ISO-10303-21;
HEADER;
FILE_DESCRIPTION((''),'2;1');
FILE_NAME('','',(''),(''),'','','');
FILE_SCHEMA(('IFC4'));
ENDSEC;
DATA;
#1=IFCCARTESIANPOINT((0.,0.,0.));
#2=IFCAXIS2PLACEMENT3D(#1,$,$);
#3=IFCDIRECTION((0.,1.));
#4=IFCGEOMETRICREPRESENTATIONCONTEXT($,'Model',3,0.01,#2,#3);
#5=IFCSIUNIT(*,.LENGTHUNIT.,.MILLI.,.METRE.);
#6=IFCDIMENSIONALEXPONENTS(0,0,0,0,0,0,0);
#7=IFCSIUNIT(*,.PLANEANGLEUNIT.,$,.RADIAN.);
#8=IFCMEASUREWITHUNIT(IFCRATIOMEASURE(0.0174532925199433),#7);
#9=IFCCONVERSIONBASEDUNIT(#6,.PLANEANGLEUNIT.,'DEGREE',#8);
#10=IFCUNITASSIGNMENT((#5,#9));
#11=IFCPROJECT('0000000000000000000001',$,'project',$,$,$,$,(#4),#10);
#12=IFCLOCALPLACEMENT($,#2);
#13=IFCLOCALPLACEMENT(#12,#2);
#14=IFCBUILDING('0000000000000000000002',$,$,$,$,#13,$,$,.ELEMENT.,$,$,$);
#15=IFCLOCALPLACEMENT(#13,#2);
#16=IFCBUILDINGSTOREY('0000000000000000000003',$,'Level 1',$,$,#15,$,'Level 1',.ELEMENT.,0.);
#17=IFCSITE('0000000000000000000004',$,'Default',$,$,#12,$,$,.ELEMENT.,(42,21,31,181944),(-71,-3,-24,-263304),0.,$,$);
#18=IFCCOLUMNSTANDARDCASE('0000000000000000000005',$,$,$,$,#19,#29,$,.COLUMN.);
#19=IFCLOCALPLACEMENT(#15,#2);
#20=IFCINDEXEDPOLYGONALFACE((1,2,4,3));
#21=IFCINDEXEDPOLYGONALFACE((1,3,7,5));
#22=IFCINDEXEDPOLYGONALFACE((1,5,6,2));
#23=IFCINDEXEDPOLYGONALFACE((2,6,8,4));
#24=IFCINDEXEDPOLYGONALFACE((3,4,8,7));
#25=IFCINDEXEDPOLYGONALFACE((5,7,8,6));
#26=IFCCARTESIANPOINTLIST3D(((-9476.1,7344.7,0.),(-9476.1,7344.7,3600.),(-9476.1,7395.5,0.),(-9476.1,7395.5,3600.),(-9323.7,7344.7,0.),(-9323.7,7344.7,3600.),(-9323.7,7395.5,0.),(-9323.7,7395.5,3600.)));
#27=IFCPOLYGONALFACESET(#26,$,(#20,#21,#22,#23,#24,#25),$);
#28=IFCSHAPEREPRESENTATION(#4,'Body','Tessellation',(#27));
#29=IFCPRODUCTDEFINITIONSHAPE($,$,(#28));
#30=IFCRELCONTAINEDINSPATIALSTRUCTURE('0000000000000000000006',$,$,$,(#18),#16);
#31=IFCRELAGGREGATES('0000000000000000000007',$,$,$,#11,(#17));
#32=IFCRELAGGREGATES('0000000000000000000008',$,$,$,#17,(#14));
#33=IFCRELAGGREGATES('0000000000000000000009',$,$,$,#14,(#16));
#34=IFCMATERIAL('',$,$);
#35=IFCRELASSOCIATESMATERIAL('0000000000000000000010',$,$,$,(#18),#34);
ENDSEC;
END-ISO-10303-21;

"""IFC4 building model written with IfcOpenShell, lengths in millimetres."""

from ifc_helpers import new_model, entity, si_unit, converted_unit, direction, frame, origin, place, context, project, spatial, rectangle, extrude, material, element, save


model = new_model("IFC4")

# Units and contexts
model_context = context("Model", 3, precision=0.01, world=origin(), true_north=direction((0.0, 1.0)))
ifc_project = project(units=[si_unit("LENGTHUNIT", "METRE", prefix="MILLI"), converted_unit("PLANEANGLEUNIT", "DEGREE", entity("IfcRatioMeasure", 0.0174532925199433), si_unit("PLANEANGLEUNIT", "RADIAN"), dimensions=[0, 0, 0, 0, 0, 0, 0])], contexts=[model_context])

# Site, building, storey
site_placement = place(None, origin())
site = spatial("IfcSite", under=ifc_project, at=site_placement, Name="Default", CompositionType="ELEMENT", RefLatitude=(42, 21, 31, 181944), RefLongitude=(-71, -3, -24, -263304), RefElevation=0.0)
building_placement = place(site_placement, origin())
building = spatial("IfcBuilding", under=site, at=building_placement, CompositionType="ELEMENT")
storey_placement = place(building_placement, origin())
storey = spatial("IfcBuildingStorey", under=building, at=storey_placement, Name="Level 1", LongName="Level 1", CompositionType="ELEMENT", Elevation=0.0)

# Column
ifc_material_1 = material(Name="")
placement_1 = place(storey_placement, frame((-9399.9, 7344.7, 0.0), z_axis=(0.0, 0.0, 1.0), x_axis=(0.0, 1.0, 0.0)))
for number, where, z_axis, x_axis in (
    (1, (25.4, 0.0, 0.0), (0.0, 0.0, 1.0), (1.0, 0.0, 0.0)),
):
    element("IfcColumnStandardCase", number, at=place(placement_1, frame(where, z_axis=z_axis, x_axis=x_axis)), inside=storey, material=ifc_material_1, PredefinedType="COLUMN", context=model_context, shape_type="SweptSolid", body=[
        extrude(rectangle(XDim=50.8, YDim=152.4), origin(), (0.0, 0.0, 1.0), 3600.0),
    ])

save(model, "model.ifc")
